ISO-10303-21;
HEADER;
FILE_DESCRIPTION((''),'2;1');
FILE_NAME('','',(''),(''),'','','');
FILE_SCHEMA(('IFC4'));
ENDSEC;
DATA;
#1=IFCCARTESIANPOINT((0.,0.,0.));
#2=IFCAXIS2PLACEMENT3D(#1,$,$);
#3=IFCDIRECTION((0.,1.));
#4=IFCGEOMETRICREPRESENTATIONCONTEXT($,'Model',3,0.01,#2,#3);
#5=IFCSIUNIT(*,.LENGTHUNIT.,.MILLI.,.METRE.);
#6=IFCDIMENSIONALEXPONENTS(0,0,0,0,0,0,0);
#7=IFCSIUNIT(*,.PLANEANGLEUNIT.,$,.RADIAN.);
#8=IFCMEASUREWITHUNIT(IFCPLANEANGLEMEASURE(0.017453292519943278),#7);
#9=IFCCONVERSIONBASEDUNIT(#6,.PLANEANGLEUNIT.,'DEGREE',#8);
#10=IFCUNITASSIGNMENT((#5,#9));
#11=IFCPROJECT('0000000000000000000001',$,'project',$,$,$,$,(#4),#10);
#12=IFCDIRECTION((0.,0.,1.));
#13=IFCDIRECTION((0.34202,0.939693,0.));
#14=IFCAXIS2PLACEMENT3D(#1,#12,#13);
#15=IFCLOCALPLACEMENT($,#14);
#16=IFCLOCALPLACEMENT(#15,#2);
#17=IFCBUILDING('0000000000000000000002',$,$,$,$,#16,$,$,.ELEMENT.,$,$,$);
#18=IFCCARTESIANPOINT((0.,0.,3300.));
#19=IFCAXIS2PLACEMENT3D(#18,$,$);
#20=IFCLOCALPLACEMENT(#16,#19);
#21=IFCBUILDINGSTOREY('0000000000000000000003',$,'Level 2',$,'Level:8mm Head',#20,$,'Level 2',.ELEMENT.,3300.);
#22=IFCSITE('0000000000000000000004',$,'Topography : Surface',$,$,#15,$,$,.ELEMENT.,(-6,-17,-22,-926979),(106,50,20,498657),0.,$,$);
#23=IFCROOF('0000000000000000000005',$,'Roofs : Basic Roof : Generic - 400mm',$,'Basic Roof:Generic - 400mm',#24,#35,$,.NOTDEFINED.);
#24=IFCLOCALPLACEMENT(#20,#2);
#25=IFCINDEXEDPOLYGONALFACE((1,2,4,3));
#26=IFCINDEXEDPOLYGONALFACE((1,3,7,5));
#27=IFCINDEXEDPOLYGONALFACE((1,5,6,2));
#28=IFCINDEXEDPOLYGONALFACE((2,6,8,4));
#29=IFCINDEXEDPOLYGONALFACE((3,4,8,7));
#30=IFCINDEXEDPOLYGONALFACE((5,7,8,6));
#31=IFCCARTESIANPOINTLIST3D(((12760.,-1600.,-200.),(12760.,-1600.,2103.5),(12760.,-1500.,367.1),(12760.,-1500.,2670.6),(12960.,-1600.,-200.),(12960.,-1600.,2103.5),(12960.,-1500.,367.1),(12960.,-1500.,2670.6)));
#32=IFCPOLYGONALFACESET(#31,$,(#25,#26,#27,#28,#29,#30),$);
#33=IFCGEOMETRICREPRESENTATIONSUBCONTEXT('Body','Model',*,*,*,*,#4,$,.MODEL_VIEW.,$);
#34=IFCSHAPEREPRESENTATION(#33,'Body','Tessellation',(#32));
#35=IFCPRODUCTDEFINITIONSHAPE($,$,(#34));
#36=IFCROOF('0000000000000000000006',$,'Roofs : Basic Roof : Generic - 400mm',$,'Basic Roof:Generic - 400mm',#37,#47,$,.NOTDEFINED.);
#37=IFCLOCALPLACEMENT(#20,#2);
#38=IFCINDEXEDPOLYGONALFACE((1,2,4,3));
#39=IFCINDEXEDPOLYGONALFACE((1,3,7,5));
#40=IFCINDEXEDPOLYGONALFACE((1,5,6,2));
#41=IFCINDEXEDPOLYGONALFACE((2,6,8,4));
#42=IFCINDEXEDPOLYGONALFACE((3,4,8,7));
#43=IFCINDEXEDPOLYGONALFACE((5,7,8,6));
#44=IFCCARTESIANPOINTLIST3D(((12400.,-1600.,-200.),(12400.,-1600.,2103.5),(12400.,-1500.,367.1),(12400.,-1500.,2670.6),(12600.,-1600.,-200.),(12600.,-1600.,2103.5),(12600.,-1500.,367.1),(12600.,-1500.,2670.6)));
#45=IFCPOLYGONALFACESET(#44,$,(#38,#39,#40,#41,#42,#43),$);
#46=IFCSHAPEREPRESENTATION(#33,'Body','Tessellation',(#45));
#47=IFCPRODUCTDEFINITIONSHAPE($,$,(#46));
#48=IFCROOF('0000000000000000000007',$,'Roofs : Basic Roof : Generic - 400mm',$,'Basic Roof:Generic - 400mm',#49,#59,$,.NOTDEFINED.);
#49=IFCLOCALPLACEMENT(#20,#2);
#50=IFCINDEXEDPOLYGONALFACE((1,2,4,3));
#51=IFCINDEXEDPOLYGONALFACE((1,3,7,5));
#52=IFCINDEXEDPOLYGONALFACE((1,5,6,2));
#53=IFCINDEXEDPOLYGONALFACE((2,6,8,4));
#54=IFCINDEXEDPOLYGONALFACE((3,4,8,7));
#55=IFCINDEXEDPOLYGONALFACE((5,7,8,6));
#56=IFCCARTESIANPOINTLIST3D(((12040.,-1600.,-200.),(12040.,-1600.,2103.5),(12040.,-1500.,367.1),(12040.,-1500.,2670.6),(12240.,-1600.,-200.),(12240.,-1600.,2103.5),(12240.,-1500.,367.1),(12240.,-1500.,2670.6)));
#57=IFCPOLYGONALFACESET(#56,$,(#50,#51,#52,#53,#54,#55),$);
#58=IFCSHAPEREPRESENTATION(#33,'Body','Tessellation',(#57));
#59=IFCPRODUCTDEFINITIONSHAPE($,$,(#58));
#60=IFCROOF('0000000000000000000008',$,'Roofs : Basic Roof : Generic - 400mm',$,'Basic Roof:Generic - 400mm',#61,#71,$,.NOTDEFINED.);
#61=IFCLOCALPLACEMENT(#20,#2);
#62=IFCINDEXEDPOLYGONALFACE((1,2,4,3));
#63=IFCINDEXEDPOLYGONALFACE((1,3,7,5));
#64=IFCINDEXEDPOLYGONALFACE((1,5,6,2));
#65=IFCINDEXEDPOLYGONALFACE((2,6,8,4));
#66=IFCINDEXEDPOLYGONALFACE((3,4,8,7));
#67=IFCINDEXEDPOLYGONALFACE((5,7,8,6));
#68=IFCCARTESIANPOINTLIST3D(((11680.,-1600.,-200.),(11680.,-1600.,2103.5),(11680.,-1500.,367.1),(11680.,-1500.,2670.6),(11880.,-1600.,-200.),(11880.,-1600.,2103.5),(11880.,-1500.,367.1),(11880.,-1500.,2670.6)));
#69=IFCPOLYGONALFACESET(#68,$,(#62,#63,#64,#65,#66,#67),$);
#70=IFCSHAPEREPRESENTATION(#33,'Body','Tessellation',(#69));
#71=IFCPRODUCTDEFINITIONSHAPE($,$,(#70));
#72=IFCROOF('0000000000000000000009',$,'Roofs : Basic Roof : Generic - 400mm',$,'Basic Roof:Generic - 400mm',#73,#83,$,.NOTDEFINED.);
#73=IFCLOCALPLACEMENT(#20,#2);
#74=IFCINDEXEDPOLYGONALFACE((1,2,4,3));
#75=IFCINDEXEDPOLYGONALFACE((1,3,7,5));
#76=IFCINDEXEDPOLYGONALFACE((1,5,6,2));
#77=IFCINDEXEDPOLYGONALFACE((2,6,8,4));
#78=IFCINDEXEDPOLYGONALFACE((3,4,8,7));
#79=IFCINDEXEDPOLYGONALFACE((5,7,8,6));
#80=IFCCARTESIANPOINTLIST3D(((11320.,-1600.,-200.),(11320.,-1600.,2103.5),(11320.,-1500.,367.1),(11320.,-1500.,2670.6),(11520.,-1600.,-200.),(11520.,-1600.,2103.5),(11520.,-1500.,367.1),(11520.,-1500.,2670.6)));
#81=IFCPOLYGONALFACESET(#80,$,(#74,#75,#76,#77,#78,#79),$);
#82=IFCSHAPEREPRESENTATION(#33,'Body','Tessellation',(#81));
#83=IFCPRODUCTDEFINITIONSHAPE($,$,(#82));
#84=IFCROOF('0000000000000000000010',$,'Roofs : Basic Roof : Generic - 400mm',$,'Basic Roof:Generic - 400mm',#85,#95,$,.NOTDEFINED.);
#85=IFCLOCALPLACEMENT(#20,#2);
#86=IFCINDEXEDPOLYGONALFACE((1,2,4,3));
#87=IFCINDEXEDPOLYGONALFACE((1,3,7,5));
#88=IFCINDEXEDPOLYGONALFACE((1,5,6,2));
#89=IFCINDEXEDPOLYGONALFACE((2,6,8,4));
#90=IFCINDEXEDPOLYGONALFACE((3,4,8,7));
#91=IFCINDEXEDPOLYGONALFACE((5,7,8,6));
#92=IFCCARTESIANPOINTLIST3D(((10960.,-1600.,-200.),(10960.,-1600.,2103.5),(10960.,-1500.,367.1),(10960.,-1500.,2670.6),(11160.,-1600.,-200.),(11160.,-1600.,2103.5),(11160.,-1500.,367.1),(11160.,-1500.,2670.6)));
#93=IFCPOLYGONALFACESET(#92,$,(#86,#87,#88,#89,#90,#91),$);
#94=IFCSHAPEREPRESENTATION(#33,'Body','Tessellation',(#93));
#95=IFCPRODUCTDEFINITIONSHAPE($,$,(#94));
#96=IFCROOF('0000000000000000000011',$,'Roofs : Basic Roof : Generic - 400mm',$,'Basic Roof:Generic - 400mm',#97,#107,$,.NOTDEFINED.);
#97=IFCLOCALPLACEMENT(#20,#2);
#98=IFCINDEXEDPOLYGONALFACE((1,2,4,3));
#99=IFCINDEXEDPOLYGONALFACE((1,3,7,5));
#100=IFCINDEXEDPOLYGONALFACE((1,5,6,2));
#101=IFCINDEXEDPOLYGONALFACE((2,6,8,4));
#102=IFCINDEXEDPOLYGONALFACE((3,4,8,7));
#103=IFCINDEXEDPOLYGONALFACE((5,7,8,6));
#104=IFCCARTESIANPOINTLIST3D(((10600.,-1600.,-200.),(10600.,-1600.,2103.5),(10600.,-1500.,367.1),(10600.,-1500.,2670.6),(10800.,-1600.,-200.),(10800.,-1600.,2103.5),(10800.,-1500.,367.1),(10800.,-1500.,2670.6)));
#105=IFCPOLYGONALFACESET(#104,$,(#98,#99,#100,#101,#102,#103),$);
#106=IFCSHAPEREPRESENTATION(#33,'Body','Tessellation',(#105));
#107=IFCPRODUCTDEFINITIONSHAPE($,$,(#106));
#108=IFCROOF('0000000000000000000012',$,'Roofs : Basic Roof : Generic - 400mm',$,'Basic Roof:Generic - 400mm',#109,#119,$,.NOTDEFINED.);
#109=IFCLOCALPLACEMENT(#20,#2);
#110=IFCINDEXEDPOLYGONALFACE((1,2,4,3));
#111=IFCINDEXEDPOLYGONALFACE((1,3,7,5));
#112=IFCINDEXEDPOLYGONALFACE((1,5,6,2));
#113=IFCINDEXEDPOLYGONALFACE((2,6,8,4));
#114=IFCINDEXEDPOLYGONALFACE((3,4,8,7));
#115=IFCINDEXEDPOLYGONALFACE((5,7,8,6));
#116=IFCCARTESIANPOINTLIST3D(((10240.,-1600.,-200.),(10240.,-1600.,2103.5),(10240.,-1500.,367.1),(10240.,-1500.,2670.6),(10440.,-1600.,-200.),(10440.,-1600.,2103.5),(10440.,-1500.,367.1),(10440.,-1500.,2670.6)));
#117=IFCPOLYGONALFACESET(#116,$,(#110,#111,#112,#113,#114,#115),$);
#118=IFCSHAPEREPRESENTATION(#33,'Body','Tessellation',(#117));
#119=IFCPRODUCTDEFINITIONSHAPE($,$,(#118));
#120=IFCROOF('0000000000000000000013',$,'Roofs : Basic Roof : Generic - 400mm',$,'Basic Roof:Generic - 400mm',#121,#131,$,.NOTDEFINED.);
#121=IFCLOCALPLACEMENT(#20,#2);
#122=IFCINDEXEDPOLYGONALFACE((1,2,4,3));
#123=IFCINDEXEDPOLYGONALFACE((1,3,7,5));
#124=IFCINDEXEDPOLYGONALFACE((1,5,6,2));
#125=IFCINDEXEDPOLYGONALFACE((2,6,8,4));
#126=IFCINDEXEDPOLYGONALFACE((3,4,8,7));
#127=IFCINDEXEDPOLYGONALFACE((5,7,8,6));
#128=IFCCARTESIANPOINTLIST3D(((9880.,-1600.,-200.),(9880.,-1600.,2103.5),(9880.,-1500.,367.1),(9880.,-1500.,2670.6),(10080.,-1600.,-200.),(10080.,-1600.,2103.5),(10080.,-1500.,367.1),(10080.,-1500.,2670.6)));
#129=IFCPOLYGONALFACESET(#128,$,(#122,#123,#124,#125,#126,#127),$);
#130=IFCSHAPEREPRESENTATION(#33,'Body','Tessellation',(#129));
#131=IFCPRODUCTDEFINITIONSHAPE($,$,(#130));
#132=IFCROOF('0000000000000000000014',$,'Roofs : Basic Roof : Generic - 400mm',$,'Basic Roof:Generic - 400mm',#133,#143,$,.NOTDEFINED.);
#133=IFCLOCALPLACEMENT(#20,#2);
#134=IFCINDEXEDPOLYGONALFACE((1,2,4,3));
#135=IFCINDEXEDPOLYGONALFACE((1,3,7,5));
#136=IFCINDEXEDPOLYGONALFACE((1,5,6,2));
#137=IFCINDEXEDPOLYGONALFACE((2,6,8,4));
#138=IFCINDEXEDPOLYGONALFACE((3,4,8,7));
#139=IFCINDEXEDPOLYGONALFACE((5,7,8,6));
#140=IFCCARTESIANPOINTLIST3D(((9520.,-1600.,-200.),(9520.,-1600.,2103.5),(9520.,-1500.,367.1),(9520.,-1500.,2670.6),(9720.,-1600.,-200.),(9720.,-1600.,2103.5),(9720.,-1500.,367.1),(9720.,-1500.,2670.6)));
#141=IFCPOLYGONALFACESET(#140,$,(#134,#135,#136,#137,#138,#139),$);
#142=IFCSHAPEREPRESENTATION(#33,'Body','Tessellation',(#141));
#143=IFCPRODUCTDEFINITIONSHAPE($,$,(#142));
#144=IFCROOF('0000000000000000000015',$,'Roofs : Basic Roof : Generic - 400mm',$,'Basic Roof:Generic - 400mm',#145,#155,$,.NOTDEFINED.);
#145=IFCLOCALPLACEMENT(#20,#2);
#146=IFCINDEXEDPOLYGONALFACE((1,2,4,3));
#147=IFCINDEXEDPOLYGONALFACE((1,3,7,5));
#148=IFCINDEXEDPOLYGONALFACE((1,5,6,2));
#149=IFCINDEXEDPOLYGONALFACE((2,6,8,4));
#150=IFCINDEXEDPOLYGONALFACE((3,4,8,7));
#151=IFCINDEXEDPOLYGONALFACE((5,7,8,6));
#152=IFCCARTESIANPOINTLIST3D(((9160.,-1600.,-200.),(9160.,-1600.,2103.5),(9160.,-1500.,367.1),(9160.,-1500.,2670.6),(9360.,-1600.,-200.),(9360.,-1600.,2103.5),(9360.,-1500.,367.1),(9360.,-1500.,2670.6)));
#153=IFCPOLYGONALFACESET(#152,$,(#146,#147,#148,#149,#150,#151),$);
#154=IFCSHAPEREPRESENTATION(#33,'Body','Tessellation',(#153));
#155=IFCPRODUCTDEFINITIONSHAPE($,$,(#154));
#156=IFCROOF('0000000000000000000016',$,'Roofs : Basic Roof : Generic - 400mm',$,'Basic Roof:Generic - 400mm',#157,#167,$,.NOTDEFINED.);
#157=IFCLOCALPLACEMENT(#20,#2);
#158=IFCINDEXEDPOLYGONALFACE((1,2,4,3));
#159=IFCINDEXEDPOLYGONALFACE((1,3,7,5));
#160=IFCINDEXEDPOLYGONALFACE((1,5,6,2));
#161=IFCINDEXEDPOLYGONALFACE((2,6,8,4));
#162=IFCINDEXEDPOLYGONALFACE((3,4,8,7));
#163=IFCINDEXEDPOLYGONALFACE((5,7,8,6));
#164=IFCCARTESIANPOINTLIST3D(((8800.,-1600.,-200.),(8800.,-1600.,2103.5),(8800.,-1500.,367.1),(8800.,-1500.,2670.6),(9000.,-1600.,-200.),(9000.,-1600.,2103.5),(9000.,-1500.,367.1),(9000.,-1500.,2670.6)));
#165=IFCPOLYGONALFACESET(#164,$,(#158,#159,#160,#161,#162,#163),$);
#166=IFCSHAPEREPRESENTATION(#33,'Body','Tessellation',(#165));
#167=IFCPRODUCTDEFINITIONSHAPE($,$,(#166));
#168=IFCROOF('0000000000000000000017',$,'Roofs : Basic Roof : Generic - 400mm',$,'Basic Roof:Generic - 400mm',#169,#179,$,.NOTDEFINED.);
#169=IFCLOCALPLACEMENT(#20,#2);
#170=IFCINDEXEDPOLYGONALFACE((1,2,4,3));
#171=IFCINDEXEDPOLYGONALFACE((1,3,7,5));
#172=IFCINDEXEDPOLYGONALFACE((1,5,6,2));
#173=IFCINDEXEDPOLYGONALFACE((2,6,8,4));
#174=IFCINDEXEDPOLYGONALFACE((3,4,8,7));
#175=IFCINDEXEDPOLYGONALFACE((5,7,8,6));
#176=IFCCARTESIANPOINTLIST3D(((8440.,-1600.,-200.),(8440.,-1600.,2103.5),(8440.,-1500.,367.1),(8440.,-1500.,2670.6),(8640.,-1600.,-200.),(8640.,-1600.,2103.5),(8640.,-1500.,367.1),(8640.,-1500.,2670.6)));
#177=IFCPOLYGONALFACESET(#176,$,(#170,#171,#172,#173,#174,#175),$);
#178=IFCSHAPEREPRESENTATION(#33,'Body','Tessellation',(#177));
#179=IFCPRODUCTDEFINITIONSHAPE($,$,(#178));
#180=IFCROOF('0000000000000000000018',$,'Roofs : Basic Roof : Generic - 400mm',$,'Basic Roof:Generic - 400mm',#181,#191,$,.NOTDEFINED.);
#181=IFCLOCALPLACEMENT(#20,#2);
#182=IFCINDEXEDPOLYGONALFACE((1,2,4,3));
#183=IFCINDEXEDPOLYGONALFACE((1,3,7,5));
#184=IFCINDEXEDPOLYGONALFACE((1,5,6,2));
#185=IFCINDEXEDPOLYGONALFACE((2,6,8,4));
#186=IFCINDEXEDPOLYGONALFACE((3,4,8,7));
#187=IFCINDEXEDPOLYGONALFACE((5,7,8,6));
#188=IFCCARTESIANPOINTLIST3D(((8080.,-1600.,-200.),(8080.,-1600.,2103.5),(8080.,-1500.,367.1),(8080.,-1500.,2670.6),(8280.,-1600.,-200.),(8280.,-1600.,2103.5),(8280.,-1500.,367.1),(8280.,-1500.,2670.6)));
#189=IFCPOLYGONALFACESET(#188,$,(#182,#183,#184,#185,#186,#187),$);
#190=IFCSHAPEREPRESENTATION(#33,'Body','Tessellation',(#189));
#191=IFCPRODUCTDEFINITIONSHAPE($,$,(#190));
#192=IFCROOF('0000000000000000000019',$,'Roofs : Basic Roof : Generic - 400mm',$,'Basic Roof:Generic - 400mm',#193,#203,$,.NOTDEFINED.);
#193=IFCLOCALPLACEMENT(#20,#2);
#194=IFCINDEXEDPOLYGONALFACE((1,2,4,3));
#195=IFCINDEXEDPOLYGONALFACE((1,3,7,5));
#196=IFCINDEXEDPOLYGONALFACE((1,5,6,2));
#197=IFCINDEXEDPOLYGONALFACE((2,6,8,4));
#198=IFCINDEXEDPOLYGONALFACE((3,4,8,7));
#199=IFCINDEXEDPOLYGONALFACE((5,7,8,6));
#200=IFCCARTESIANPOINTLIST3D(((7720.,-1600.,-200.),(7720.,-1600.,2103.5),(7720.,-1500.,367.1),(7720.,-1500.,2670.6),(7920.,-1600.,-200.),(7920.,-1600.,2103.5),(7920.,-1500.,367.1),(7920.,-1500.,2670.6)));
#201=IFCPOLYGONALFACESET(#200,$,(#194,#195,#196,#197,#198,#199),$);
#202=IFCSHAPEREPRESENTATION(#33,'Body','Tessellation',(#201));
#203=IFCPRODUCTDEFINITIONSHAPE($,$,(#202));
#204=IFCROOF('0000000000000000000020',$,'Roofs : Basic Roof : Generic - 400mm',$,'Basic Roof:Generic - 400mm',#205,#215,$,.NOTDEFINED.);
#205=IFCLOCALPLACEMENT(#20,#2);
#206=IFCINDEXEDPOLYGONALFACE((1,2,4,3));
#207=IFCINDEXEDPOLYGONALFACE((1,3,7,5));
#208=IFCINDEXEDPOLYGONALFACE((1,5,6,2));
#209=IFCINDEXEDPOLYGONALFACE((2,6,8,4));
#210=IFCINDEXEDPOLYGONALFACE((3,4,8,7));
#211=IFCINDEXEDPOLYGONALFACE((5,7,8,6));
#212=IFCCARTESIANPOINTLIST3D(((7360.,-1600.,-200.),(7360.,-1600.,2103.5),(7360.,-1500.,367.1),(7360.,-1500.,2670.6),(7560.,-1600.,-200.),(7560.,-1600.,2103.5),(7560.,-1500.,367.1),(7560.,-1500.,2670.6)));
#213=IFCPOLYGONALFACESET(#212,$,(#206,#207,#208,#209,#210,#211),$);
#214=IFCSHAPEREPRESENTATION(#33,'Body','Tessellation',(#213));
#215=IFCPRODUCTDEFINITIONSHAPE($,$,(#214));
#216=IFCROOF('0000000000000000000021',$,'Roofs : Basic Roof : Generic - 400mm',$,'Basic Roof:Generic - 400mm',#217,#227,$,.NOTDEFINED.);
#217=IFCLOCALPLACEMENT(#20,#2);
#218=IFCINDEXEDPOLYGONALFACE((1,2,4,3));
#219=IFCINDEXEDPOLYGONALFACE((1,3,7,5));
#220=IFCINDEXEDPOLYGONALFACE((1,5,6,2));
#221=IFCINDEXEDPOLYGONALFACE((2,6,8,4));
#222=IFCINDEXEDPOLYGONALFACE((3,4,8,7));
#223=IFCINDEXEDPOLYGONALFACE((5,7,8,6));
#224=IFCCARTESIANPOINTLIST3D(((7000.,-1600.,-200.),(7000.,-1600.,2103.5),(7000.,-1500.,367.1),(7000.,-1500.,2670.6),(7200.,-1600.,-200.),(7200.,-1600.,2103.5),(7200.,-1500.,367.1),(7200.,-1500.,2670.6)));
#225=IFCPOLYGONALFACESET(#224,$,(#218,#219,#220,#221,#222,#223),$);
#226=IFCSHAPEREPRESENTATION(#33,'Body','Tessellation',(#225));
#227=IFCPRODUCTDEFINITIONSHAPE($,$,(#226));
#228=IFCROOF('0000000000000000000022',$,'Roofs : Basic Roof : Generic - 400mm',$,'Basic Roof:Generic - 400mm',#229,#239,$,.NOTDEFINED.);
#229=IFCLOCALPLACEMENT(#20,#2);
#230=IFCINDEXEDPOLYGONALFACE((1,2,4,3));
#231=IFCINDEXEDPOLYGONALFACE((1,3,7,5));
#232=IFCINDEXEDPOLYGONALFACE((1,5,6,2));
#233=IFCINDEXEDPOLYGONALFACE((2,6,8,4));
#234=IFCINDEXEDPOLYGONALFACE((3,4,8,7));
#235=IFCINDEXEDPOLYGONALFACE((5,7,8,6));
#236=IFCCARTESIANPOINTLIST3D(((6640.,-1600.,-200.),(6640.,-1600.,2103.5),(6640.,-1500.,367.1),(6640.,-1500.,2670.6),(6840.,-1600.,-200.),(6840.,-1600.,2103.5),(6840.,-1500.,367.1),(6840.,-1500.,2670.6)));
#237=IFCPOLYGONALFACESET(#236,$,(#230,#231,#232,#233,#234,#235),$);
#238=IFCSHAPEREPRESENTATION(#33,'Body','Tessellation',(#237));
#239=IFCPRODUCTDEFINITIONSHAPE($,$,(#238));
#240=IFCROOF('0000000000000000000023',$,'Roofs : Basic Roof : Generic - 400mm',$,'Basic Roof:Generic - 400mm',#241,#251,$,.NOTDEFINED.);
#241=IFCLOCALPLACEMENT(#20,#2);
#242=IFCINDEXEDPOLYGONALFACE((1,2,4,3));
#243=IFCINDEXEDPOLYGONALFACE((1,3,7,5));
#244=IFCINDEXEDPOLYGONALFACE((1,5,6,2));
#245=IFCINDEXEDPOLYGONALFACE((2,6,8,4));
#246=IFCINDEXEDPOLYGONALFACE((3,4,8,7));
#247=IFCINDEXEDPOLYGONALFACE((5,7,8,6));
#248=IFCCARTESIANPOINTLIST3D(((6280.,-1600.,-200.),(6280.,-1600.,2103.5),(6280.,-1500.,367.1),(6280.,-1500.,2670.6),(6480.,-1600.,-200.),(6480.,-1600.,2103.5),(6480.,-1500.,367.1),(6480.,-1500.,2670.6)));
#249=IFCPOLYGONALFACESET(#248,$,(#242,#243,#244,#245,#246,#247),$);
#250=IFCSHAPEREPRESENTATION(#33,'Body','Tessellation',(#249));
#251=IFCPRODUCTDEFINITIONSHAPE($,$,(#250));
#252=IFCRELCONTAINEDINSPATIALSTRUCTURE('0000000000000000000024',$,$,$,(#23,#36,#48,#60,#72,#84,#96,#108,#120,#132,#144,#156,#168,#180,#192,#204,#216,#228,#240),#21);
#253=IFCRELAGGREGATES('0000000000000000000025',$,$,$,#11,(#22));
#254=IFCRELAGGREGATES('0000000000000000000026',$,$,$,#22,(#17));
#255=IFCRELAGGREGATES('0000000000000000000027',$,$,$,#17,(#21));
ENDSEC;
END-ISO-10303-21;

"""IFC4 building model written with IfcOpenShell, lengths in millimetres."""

from ifc_helpers import new_model, entity, si_unit, converted_unit, direction, frame, origin, place, context, subcontext, project, spatial, indexed_curve, outline, extrude, element, save


model = new_model("IFC4")

# Units and contexts
model_context = context("Model", 3, precision=0.01, world=origin(), true_north=direction((0.0, 1.0)))
body_context = subcontext(model_context, "Body", "Model", "MODEL_VIEW")
ifc_project = project(units=[si_unit("LENGTHUNIT", "METRE", prefix="MILLI"), converted_unit("PLANEANGLEUNIT", "DEGREE", entity("IfcPlaneAngleMeasure", 0.017453292519943278), si_unit("PLANEANGLEUNIT", "RADIAN"), dimensions=[0, 0, 0, 0, 0, 0, 0])], contexts=[model_context])

# Site, building, storey
site_placement = place(None, frame((0.0, 0.0, 0.0), z_axis=(0.0, 0.0, 1.0), x_axis=(0.34202, 0.939693, 0.0)))
site = spatial("IfcSite", under=ifc_project, at=site_placement, Name="Topography : Surface", CompositionType="ELEMENT", RefLatitude=(-6, -17, -22, -926979), RefLongitude=(106, 50, 20, 498657), RefElevation=0.0)
building_placement = place(site_placement, origin())
building = spatial("IfcBuilding", under=site, at=building_placement, CompositionType="ELEMENT")
storey_placement = place(building_placement, frame((0.0, 0.0, 3300.0)))
storey = spatial("IfcBuildingStorey", under=building, at=storey_placement, Name="Level 2", ObjectType="Level:8mm Head", LongName="Level 2", CompositionType="ELEMENT", Elevation=3300.0)

# Roofs
for number, where, name in (
    (1, (12760.0, -1600.0, -200.0), "Roofs : Basic Roof : Generic - 400mm"),
    (2, (12400.0, -1600.0, -200.0), "Roofs : Basic Roof : Generic - 400mm"),
    (3, (12040.0, -1600.0, -200.0), "Roofs : Basic Roof : Generic - 400mm"),
    (4, (11680.0, -1600.0, -200.0), "Roofs : Basic Roof : Generic - 400mm"),
    (5, (11320.0, -1600.0, -200.0), "Roofs : Basic Roof : Generic - 400mm"),
    (6, (10960.0, -1600.0, -200.0), "Roofs : Basic Roof : Generic - 400mm"),
    (7, (10600.0, -1600.0, -200.0), "Roofs : Basic Roof : Generic - 400mm"),
    (8, (10240.0, -1600.0, -200.0), "Roofs : Basic Roof : Generic - 400mm"),
    (9, (9880.0, -1600.0, -200.0), "Roofs : Basic Roof : Generic - 400mm"),
):
    element("IfcRoof", number, at=place(storey_placement, frame(where)), inside=storey, Name=name, ObjectType="Basic Roof:Generic - 400mm", PredefinedType="NOTDEFINED", context=body_context, shape_type="SweptSolid", body=[
        extrude(outline(indexed_curve([(100.0, 287.9), (-100.0, 287.9), (-100.0, -287.9), (100.0, -287.9), (100.0, 287.9)], self_intersect=False)), frame((100.0, 50.0, 283.6), z_axis=(0.0, -0.984808, 0.173648), x_axis=(1.0, 0.0, 0.0)), (0.0, 0.984808, 0.173648), 2303.5),
    ])
for number, where, name in (
    (10, (9520.0, -1600.0, -200.0), "Roofs : Basic Roof : Generic - 400mm"),
    (11, (9160.0, -1600.0, -200.0), "Roofs : Basic Roof : Generic - 400mm"),
    (12, (8800.0, -1600.0, -200.0), "Roofs : Basic Roof : Generic - 400mm"),
    (13, (8440.0, -1600.0, -200.0), "Roofs : Basic Roof : Generic - 400mm"),
    (14, (8080.0, -1600.0, -200.0), "Roofs : Basic Roof : Generic - 400mm"),
    (15, (7720.0, -1600.0, -200.0), "Roofs : Basic Roof : Generic - 400mm"),
    (16, (7360.0, -1600.0, -200.0), "Roofs : Basic Roof : Generic - 400mm"),
    (17, (7000.0, -1600.0, -200.0), "Roofs : Basic Roof : Generic - 400mm"),
    (18, (6640.0, -1600.0, -200.0), "Roofs : Basic Roof : Generic - 400mm"),
    (19, (6280.0, -1600.0, -200.0), "Roofs : Basic Roof : Generic - 400mm"),
):
    element("IfcRoof", number, at=place(storey_placement, frame(where)), inside=storey, Name=name, ObjectType="Basic Roof:Generic - 400mm", PredefinedType="NOTDEFINED", context=body_context, shape_type="SweptSolid", body=[
        extrude(outline(indexed_curve([(100.0, 287.9), (-100.0, 287.9), (-100.0, -287.9), (100.0, -287.9), (100.0, 287.9)], self_intersect=False)), frame((100.0, 50.0, 283.6), z_axis=(0.0, -0.984808, 0.173648), x_axis=(1.0, 0.0, 0.0)), (0.0, 0.984808, 0.173648), 2303.5),
    ])

save(model, "model.ifc")
